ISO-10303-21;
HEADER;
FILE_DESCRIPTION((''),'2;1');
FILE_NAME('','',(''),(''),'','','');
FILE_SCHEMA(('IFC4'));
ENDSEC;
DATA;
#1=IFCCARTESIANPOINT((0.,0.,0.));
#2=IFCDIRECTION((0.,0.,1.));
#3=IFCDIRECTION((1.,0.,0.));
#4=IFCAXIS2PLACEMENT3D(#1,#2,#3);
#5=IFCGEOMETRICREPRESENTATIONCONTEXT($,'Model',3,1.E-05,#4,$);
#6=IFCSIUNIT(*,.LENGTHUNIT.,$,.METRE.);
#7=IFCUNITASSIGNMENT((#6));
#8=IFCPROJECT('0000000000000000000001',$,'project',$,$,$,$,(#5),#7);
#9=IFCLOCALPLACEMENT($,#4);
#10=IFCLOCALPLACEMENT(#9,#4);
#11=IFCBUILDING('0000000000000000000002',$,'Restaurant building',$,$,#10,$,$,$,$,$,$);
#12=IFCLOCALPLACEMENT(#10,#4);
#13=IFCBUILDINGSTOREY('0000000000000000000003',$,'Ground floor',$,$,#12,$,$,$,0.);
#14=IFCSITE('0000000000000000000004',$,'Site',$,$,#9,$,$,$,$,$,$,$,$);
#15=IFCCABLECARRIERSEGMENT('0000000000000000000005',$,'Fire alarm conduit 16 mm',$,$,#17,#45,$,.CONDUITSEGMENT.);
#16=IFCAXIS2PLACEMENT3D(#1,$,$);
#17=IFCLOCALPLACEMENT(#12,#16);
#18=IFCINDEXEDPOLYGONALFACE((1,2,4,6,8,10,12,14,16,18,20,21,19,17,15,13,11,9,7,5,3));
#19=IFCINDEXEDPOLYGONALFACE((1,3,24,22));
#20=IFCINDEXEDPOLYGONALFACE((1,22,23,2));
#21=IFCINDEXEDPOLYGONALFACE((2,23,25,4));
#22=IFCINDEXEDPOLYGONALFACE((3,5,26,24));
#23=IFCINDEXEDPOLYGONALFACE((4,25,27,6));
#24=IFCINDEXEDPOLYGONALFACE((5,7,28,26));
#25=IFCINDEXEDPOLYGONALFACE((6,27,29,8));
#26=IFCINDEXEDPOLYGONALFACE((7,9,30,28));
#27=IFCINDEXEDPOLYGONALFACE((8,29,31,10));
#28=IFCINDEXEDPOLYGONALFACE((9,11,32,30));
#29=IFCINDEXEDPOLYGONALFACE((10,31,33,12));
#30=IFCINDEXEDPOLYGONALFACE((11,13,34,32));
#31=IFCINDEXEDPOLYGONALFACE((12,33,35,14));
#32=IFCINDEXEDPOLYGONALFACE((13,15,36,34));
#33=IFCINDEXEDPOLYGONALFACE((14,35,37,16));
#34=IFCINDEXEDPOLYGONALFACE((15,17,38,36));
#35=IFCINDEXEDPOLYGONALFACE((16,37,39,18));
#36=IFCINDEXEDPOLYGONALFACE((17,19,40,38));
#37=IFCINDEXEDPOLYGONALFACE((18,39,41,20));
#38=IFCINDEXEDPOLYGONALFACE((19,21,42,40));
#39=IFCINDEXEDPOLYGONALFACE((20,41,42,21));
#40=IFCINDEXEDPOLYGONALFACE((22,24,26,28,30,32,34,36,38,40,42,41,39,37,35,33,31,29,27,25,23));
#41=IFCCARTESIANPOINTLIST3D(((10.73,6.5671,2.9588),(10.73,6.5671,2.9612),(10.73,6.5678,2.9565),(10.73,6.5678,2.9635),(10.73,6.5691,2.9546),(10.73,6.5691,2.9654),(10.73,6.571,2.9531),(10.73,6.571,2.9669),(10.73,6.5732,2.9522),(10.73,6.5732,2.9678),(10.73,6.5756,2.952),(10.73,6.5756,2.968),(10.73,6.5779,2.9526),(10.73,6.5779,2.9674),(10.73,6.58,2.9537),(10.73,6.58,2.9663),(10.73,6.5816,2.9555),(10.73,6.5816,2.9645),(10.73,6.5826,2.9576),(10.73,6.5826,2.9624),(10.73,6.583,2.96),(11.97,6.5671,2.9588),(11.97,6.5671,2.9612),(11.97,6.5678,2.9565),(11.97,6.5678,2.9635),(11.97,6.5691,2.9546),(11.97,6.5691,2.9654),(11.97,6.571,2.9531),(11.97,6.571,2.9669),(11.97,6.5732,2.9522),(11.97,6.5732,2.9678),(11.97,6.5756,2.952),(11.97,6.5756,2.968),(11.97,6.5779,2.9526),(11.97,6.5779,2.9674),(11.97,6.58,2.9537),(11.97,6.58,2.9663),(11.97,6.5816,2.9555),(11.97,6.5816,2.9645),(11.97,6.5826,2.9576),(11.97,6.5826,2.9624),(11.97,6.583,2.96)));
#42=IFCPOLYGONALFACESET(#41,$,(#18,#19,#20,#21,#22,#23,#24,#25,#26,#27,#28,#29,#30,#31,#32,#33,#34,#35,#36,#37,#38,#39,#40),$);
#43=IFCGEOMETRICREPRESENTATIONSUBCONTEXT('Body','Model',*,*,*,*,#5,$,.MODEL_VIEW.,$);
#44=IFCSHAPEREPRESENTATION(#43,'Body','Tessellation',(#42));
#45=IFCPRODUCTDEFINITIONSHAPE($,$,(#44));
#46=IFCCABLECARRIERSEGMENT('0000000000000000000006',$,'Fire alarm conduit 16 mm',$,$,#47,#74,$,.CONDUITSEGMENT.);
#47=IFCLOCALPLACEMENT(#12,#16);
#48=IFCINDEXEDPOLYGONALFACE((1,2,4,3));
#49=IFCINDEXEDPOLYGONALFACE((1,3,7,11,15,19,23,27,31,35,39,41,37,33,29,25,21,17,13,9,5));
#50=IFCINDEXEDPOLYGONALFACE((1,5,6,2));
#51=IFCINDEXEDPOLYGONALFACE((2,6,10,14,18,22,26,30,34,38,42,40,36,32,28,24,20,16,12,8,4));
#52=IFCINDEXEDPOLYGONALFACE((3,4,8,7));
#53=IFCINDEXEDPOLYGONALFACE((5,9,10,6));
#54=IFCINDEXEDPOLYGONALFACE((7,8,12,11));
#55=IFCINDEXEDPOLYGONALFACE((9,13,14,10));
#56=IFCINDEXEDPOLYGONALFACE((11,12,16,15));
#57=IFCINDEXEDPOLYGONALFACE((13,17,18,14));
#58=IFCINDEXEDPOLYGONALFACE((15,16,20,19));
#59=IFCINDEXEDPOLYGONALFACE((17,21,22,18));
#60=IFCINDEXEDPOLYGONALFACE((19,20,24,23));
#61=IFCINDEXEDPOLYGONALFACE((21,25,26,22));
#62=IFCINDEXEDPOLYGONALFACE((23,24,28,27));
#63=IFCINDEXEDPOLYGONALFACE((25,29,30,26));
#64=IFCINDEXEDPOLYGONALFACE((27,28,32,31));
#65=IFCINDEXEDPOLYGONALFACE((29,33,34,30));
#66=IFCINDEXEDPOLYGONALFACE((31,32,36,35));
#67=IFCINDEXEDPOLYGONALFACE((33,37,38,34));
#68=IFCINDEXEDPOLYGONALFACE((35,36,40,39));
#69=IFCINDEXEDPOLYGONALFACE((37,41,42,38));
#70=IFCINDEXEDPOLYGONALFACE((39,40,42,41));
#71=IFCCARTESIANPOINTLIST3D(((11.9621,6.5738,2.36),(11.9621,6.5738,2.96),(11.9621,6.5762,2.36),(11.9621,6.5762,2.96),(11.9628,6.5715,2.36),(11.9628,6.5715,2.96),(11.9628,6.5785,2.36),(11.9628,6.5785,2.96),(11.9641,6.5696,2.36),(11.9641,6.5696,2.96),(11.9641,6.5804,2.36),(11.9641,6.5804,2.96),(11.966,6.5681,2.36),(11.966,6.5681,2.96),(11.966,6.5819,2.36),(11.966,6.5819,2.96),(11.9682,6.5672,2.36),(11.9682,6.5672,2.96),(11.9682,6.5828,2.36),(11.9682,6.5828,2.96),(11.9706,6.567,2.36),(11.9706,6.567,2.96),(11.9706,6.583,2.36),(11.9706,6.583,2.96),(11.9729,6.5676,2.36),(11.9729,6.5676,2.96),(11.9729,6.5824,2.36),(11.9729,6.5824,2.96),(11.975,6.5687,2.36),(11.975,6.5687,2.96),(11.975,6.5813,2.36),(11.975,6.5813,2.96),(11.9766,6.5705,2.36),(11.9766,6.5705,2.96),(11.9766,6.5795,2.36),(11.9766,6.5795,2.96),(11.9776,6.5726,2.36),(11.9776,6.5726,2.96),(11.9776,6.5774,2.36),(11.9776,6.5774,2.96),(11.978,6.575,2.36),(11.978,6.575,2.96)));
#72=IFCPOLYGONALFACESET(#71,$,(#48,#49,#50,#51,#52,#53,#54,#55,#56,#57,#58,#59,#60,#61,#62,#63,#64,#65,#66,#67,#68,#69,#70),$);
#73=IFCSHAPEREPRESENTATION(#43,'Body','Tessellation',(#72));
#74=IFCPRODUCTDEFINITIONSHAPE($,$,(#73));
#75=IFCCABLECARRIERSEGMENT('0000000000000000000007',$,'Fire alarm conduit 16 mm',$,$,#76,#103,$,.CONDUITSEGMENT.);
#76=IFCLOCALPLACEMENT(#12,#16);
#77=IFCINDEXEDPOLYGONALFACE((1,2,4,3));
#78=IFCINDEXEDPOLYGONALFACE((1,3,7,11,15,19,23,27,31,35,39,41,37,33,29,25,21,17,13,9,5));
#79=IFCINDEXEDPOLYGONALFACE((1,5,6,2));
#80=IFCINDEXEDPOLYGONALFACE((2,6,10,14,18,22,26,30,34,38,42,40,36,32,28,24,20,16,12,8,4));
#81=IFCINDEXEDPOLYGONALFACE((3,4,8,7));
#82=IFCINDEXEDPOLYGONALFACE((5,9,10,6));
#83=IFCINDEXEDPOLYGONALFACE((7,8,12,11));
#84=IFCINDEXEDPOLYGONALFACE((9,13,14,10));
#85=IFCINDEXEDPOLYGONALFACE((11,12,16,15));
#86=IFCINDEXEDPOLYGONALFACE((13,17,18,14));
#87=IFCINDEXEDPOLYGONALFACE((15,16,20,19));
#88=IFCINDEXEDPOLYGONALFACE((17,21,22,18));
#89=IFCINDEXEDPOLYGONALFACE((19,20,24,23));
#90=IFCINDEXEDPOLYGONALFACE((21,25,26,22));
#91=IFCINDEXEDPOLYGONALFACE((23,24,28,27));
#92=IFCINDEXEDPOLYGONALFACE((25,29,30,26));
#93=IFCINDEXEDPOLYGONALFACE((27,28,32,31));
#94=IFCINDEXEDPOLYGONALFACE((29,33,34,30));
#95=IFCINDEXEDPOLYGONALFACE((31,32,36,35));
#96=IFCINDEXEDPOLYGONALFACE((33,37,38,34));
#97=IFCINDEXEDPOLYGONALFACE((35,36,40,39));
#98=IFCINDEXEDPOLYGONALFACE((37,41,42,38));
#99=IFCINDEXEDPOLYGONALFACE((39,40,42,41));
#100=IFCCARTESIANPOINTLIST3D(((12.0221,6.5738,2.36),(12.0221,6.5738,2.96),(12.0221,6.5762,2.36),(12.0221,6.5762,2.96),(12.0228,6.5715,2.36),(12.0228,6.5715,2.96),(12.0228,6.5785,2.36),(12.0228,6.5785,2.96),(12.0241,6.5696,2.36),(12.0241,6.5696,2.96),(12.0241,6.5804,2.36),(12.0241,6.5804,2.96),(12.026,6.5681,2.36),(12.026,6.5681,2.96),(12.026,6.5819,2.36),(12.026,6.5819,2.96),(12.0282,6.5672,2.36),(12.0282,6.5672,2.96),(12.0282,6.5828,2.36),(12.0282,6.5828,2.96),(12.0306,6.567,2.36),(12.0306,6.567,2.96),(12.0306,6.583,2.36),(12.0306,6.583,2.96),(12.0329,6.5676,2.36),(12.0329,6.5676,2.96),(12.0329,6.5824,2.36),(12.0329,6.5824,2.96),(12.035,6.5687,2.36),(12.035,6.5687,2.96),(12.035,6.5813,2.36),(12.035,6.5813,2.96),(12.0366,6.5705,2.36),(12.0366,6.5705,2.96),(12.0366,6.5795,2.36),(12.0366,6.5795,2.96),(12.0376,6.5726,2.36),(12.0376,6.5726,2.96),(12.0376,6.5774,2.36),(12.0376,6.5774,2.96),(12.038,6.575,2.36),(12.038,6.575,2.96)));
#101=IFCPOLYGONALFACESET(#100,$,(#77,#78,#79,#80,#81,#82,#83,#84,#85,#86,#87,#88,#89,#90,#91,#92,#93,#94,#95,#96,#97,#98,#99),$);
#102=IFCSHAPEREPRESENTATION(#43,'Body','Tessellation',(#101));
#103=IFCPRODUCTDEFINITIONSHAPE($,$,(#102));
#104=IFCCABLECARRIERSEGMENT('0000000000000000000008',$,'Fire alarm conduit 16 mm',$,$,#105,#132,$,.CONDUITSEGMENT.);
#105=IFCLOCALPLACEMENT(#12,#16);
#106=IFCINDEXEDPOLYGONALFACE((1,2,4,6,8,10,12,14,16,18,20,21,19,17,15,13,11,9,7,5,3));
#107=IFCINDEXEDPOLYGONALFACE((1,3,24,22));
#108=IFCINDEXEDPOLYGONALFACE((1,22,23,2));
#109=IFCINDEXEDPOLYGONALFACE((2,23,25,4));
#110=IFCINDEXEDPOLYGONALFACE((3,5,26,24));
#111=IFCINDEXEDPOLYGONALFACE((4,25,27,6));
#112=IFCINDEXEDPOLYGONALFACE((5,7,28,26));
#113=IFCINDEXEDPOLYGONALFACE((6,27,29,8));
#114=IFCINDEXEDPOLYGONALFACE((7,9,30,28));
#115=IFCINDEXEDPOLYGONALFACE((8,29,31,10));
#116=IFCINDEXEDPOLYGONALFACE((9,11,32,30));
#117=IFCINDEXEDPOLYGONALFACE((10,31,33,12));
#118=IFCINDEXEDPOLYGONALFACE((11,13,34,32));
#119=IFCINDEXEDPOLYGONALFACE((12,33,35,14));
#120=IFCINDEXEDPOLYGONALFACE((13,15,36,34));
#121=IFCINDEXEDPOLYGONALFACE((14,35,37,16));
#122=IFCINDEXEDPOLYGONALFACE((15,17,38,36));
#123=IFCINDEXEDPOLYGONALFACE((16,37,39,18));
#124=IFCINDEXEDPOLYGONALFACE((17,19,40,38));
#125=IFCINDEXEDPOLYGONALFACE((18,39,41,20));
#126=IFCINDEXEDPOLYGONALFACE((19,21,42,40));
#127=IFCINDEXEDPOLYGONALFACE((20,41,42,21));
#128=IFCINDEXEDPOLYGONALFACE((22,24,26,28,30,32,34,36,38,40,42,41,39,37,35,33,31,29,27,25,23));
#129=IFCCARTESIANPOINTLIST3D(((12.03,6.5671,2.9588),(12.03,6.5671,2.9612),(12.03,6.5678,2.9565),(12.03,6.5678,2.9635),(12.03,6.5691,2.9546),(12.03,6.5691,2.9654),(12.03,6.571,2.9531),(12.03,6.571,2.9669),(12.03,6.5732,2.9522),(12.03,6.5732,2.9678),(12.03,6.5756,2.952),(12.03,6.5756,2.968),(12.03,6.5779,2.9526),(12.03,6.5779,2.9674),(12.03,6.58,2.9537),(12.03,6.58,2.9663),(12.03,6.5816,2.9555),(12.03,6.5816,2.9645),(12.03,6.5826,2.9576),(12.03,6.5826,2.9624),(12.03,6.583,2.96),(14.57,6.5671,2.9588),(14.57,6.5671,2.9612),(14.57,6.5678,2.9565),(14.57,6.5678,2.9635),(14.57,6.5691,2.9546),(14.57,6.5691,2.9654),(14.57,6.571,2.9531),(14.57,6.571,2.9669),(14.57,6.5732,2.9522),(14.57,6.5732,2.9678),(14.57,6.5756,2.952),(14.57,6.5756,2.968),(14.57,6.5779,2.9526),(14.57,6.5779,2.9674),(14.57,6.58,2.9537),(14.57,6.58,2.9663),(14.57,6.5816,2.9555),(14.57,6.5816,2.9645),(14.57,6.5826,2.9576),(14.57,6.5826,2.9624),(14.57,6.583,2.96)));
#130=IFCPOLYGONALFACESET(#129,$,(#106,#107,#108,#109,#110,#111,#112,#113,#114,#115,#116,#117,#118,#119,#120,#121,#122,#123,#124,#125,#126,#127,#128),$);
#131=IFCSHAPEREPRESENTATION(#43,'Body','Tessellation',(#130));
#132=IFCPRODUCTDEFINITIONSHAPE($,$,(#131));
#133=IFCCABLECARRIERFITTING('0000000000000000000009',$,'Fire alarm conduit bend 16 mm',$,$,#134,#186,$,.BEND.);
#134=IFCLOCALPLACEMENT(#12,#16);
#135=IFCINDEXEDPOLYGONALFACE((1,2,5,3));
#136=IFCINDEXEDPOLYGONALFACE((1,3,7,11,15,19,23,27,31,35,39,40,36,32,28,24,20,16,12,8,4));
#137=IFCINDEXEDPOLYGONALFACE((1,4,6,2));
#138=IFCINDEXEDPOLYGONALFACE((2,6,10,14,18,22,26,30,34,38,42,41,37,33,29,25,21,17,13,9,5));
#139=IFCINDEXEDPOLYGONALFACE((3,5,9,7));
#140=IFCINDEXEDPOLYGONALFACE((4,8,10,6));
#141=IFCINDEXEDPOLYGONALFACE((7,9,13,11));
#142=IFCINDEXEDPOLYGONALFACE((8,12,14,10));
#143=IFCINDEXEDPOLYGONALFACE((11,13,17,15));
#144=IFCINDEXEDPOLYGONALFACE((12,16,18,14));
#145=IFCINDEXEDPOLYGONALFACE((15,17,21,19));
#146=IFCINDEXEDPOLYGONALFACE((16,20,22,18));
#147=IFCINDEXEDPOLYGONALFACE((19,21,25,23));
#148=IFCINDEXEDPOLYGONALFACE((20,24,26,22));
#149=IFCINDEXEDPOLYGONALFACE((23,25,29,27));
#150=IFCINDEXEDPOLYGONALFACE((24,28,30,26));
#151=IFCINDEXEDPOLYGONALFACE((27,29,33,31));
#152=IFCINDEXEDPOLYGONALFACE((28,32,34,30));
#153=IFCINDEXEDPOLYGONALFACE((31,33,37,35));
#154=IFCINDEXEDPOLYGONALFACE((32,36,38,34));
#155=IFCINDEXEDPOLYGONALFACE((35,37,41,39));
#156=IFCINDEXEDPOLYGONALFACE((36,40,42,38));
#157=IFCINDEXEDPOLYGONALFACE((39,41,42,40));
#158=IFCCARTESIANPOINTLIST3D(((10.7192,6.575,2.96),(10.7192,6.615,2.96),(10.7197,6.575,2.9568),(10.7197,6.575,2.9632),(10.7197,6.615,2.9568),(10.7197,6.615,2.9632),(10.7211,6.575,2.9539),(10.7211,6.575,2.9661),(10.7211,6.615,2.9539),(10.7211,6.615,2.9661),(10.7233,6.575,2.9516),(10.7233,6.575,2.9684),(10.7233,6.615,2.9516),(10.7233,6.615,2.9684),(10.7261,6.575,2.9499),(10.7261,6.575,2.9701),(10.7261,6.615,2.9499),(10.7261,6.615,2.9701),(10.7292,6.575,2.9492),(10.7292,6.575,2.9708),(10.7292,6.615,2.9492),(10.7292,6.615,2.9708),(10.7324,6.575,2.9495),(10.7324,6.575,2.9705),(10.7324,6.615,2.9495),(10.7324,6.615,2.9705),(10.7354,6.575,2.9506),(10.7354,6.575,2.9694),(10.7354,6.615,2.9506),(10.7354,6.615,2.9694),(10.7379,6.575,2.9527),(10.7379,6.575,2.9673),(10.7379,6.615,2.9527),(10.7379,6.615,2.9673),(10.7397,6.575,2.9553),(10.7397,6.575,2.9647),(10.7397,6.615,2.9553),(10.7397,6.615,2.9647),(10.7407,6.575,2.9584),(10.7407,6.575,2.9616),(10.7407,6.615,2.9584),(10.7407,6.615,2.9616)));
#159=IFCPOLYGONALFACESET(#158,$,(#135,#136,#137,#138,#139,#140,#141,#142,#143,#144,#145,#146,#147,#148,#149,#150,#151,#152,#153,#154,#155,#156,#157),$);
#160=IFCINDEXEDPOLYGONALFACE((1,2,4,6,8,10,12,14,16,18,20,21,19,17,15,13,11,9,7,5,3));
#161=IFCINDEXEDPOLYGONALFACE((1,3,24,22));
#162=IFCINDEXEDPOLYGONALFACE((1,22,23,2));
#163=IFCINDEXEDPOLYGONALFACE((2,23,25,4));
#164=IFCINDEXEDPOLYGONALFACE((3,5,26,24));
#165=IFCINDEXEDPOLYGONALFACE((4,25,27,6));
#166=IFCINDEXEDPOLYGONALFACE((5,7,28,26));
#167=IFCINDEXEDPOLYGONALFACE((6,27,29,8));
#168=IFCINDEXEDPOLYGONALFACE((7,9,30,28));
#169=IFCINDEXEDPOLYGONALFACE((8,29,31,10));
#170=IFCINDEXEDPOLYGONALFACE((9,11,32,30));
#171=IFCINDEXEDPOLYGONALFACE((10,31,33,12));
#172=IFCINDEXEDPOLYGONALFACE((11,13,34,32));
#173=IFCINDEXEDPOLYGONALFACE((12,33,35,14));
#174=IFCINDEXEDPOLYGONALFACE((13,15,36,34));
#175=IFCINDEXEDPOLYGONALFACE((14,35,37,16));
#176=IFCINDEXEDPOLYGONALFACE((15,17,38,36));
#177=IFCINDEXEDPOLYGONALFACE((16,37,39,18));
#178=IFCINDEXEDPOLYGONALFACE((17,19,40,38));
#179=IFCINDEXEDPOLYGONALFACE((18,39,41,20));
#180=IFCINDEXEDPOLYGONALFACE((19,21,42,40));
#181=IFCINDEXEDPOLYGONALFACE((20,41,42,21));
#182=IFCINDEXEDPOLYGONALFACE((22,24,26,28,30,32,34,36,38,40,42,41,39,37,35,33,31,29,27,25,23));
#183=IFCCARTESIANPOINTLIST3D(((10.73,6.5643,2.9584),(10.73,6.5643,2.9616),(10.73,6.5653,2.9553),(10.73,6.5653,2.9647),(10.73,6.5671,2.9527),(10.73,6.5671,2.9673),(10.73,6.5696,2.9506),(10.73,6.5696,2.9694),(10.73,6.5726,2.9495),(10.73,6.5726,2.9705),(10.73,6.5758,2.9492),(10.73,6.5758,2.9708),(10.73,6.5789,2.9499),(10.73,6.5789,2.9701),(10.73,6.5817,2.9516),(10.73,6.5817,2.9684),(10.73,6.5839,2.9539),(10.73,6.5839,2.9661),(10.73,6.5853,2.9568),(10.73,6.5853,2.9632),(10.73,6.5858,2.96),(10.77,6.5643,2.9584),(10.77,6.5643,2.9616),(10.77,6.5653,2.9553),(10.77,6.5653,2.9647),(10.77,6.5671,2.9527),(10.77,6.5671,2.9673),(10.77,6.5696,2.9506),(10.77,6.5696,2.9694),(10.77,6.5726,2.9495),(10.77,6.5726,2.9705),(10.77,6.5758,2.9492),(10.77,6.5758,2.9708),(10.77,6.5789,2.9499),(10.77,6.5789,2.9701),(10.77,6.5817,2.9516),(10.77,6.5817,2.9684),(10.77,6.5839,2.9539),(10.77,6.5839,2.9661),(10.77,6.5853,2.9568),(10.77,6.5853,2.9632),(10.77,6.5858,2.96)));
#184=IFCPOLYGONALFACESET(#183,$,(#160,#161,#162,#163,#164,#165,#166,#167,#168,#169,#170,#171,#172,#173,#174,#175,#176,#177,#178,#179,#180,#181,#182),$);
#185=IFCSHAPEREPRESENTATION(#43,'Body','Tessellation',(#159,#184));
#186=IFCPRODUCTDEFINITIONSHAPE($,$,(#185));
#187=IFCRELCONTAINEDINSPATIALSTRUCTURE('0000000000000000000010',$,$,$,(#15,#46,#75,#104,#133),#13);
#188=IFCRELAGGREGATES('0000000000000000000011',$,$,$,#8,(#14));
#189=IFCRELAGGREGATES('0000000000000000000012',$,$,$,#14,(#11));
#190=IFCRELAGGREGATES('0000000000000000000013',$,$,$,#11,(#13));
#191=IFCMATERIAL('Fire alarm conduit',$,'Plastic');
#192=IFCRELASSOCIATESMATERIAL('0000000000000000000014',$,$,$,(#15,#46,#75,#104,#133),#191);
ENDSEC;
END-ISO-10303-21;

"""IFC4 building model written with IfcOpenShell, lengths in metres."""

from ifc_helpers import new_model, si_unit, frame, origin, origin_with_axes, origin_2d, place, context, subcontext, project, spatial, circle, extrude, material, element, save


model = new_model("IFC4")

# Units and contexts
model_context = context("Model", 3, precision=1e-05, world=origin_with_axes())
body_context = subcontext(model_context, "Body", "Model", "MODEL_VIEW")
ifc_project = project(units=[si_unit("LENGTHUNIT", "METRE")], contexts=[model_context])

# Site, building, storey
site_placement = place(None, origin_with_axes())
site = spatial("IfcSite", under=ifc_project, at=site_placement, Name="Site")
building_placement = place(site_placement, origin_with_axes())
building = spatial("IfcBuilding", under=site, at=building_placement, Name="Restaurant building")
storey_placement = place(building_placement, origin_with_axes())
storey = spatial("IfcBuildingStorey", under=building, at=storey_placement, Name="Ground floor", Elevation=0.0)

# Cable carrier segments
ifc_material_1 = material(Name="Fire alarm conduit", Category="Plastic")
cable_carrier_segment_1_placement = place(storey_placement, frame((10.73, 6.575, 2.96)))
element("IfcCableCarrierSegment", 1, at=cable_carrier_segment_1_placement, inside=storey, material=ifc_material_1, Name="Fire alarm conduit 16 mm", PredefinedType="CONDUITSEGMENT", context=body_context, shape_type="SweptSolid", body=[
    extrude(circle(Radius=0.008, at=origin_2d()), frame((0.0, 0.0, 0.0), z_axis=(1.0, 0.0, 0.0), x_axis=(0.0, 1.0, 0.0)), (0.0, 0.0, 1.0), 1.24),
])
cable_carrier_segment_2_placement = place(storey_placement, frame((11.97, 6.575, 2.96)))
element("IfcCableCarrierSegment", 2, at=cable_carrier_segment_2_placement, inside=storey, material=ifc_material_1, Name="Fire alarm conduit 16 mm", PredefinedType="CONDUITSEGMENT", context=body_context, shape_type="SweptSolid", body=[
    extrude(circle(Radius=0.008, at=origin_2d()), frame((0.0, 0.0, 0.0), z_axis=(0.0, 0.0, -1.0), x_axis=(1.0, 0.0, 0.0)), (0.0, 0.0, 1.0), 0.6),
])
cable_carrier_segment_3_placement = place(storey_placement, frame((12.03, 6.575, 2.36)))
element("IfcCableCarrierSegment", 3, at=cable_carrier_segment_3_placement, inside=storey, material=ifc_material_1, Name="Fire alarm conduit 16 mm", PredefinedType="CONDUITSEGMENT", context=body_context, shape_type="SweptSolid", body=[
    extrude(circle(Radius=0.008, at=origin_2d()), origin(), (0.0, 0.0, 1.0), 0.6),
])
cable_carrier_segment_4_placement = place(storey_placement, frame((12.03, 6.575, 2.96)))
element("IfcCableCarrierSegment", 4, at=cable_carrier_segment_4_placement, inside=storey, material=ifc_material_1, Name="Fire alarm conduit 16 mm", PredefinedType="CONDUITSEGMENT", context=body_context, shape_type="SweptSolid", body=[
    extrude(circle(Radius=0.008, at=origin_2d()), frame((0.0, 0.0, 0.0), z_axis=(1.0, 0.0, 0.0), x_axis=(0.0, 1.0, 0.0)), (0.0, 0.0, 1.0), 2.54),
])

# Cable carrier fitting
cable_carrier_fitting_1_placement = place(storey_placement, frame((10.73, 6.575, 2.96)))
element("IfcCableCarrierFitting", 5, at=cable_carrier_fitting_1_placement, inside=storey, material=ifc_material_1, Name="Fire alarm conduit bend 16 mm", PredefinedType="BEND", context=body_context, shape_type="SweptSolid", body=[
    extrude(circle(Radius=0.0108, at=origin_2d()), frame((0.0, 0.0, 0.0), z_axis=(0.0, 1.0, 0.0), x_axis=(-1.0, 0.0, 0.0)), (0.0, 0.0, 1.0), 0.04),
    extrude(circle(Radius=0.0108, at=origin_2d()), frame((0.0, 0.0, 0.0), z_axis=(1.0, 0.0, 0.0), x_axis=(0.0, 1.0, 0.0)), (0.0, 0.0, 1.0), 0.04),
])

save(model, "model.ifc")
